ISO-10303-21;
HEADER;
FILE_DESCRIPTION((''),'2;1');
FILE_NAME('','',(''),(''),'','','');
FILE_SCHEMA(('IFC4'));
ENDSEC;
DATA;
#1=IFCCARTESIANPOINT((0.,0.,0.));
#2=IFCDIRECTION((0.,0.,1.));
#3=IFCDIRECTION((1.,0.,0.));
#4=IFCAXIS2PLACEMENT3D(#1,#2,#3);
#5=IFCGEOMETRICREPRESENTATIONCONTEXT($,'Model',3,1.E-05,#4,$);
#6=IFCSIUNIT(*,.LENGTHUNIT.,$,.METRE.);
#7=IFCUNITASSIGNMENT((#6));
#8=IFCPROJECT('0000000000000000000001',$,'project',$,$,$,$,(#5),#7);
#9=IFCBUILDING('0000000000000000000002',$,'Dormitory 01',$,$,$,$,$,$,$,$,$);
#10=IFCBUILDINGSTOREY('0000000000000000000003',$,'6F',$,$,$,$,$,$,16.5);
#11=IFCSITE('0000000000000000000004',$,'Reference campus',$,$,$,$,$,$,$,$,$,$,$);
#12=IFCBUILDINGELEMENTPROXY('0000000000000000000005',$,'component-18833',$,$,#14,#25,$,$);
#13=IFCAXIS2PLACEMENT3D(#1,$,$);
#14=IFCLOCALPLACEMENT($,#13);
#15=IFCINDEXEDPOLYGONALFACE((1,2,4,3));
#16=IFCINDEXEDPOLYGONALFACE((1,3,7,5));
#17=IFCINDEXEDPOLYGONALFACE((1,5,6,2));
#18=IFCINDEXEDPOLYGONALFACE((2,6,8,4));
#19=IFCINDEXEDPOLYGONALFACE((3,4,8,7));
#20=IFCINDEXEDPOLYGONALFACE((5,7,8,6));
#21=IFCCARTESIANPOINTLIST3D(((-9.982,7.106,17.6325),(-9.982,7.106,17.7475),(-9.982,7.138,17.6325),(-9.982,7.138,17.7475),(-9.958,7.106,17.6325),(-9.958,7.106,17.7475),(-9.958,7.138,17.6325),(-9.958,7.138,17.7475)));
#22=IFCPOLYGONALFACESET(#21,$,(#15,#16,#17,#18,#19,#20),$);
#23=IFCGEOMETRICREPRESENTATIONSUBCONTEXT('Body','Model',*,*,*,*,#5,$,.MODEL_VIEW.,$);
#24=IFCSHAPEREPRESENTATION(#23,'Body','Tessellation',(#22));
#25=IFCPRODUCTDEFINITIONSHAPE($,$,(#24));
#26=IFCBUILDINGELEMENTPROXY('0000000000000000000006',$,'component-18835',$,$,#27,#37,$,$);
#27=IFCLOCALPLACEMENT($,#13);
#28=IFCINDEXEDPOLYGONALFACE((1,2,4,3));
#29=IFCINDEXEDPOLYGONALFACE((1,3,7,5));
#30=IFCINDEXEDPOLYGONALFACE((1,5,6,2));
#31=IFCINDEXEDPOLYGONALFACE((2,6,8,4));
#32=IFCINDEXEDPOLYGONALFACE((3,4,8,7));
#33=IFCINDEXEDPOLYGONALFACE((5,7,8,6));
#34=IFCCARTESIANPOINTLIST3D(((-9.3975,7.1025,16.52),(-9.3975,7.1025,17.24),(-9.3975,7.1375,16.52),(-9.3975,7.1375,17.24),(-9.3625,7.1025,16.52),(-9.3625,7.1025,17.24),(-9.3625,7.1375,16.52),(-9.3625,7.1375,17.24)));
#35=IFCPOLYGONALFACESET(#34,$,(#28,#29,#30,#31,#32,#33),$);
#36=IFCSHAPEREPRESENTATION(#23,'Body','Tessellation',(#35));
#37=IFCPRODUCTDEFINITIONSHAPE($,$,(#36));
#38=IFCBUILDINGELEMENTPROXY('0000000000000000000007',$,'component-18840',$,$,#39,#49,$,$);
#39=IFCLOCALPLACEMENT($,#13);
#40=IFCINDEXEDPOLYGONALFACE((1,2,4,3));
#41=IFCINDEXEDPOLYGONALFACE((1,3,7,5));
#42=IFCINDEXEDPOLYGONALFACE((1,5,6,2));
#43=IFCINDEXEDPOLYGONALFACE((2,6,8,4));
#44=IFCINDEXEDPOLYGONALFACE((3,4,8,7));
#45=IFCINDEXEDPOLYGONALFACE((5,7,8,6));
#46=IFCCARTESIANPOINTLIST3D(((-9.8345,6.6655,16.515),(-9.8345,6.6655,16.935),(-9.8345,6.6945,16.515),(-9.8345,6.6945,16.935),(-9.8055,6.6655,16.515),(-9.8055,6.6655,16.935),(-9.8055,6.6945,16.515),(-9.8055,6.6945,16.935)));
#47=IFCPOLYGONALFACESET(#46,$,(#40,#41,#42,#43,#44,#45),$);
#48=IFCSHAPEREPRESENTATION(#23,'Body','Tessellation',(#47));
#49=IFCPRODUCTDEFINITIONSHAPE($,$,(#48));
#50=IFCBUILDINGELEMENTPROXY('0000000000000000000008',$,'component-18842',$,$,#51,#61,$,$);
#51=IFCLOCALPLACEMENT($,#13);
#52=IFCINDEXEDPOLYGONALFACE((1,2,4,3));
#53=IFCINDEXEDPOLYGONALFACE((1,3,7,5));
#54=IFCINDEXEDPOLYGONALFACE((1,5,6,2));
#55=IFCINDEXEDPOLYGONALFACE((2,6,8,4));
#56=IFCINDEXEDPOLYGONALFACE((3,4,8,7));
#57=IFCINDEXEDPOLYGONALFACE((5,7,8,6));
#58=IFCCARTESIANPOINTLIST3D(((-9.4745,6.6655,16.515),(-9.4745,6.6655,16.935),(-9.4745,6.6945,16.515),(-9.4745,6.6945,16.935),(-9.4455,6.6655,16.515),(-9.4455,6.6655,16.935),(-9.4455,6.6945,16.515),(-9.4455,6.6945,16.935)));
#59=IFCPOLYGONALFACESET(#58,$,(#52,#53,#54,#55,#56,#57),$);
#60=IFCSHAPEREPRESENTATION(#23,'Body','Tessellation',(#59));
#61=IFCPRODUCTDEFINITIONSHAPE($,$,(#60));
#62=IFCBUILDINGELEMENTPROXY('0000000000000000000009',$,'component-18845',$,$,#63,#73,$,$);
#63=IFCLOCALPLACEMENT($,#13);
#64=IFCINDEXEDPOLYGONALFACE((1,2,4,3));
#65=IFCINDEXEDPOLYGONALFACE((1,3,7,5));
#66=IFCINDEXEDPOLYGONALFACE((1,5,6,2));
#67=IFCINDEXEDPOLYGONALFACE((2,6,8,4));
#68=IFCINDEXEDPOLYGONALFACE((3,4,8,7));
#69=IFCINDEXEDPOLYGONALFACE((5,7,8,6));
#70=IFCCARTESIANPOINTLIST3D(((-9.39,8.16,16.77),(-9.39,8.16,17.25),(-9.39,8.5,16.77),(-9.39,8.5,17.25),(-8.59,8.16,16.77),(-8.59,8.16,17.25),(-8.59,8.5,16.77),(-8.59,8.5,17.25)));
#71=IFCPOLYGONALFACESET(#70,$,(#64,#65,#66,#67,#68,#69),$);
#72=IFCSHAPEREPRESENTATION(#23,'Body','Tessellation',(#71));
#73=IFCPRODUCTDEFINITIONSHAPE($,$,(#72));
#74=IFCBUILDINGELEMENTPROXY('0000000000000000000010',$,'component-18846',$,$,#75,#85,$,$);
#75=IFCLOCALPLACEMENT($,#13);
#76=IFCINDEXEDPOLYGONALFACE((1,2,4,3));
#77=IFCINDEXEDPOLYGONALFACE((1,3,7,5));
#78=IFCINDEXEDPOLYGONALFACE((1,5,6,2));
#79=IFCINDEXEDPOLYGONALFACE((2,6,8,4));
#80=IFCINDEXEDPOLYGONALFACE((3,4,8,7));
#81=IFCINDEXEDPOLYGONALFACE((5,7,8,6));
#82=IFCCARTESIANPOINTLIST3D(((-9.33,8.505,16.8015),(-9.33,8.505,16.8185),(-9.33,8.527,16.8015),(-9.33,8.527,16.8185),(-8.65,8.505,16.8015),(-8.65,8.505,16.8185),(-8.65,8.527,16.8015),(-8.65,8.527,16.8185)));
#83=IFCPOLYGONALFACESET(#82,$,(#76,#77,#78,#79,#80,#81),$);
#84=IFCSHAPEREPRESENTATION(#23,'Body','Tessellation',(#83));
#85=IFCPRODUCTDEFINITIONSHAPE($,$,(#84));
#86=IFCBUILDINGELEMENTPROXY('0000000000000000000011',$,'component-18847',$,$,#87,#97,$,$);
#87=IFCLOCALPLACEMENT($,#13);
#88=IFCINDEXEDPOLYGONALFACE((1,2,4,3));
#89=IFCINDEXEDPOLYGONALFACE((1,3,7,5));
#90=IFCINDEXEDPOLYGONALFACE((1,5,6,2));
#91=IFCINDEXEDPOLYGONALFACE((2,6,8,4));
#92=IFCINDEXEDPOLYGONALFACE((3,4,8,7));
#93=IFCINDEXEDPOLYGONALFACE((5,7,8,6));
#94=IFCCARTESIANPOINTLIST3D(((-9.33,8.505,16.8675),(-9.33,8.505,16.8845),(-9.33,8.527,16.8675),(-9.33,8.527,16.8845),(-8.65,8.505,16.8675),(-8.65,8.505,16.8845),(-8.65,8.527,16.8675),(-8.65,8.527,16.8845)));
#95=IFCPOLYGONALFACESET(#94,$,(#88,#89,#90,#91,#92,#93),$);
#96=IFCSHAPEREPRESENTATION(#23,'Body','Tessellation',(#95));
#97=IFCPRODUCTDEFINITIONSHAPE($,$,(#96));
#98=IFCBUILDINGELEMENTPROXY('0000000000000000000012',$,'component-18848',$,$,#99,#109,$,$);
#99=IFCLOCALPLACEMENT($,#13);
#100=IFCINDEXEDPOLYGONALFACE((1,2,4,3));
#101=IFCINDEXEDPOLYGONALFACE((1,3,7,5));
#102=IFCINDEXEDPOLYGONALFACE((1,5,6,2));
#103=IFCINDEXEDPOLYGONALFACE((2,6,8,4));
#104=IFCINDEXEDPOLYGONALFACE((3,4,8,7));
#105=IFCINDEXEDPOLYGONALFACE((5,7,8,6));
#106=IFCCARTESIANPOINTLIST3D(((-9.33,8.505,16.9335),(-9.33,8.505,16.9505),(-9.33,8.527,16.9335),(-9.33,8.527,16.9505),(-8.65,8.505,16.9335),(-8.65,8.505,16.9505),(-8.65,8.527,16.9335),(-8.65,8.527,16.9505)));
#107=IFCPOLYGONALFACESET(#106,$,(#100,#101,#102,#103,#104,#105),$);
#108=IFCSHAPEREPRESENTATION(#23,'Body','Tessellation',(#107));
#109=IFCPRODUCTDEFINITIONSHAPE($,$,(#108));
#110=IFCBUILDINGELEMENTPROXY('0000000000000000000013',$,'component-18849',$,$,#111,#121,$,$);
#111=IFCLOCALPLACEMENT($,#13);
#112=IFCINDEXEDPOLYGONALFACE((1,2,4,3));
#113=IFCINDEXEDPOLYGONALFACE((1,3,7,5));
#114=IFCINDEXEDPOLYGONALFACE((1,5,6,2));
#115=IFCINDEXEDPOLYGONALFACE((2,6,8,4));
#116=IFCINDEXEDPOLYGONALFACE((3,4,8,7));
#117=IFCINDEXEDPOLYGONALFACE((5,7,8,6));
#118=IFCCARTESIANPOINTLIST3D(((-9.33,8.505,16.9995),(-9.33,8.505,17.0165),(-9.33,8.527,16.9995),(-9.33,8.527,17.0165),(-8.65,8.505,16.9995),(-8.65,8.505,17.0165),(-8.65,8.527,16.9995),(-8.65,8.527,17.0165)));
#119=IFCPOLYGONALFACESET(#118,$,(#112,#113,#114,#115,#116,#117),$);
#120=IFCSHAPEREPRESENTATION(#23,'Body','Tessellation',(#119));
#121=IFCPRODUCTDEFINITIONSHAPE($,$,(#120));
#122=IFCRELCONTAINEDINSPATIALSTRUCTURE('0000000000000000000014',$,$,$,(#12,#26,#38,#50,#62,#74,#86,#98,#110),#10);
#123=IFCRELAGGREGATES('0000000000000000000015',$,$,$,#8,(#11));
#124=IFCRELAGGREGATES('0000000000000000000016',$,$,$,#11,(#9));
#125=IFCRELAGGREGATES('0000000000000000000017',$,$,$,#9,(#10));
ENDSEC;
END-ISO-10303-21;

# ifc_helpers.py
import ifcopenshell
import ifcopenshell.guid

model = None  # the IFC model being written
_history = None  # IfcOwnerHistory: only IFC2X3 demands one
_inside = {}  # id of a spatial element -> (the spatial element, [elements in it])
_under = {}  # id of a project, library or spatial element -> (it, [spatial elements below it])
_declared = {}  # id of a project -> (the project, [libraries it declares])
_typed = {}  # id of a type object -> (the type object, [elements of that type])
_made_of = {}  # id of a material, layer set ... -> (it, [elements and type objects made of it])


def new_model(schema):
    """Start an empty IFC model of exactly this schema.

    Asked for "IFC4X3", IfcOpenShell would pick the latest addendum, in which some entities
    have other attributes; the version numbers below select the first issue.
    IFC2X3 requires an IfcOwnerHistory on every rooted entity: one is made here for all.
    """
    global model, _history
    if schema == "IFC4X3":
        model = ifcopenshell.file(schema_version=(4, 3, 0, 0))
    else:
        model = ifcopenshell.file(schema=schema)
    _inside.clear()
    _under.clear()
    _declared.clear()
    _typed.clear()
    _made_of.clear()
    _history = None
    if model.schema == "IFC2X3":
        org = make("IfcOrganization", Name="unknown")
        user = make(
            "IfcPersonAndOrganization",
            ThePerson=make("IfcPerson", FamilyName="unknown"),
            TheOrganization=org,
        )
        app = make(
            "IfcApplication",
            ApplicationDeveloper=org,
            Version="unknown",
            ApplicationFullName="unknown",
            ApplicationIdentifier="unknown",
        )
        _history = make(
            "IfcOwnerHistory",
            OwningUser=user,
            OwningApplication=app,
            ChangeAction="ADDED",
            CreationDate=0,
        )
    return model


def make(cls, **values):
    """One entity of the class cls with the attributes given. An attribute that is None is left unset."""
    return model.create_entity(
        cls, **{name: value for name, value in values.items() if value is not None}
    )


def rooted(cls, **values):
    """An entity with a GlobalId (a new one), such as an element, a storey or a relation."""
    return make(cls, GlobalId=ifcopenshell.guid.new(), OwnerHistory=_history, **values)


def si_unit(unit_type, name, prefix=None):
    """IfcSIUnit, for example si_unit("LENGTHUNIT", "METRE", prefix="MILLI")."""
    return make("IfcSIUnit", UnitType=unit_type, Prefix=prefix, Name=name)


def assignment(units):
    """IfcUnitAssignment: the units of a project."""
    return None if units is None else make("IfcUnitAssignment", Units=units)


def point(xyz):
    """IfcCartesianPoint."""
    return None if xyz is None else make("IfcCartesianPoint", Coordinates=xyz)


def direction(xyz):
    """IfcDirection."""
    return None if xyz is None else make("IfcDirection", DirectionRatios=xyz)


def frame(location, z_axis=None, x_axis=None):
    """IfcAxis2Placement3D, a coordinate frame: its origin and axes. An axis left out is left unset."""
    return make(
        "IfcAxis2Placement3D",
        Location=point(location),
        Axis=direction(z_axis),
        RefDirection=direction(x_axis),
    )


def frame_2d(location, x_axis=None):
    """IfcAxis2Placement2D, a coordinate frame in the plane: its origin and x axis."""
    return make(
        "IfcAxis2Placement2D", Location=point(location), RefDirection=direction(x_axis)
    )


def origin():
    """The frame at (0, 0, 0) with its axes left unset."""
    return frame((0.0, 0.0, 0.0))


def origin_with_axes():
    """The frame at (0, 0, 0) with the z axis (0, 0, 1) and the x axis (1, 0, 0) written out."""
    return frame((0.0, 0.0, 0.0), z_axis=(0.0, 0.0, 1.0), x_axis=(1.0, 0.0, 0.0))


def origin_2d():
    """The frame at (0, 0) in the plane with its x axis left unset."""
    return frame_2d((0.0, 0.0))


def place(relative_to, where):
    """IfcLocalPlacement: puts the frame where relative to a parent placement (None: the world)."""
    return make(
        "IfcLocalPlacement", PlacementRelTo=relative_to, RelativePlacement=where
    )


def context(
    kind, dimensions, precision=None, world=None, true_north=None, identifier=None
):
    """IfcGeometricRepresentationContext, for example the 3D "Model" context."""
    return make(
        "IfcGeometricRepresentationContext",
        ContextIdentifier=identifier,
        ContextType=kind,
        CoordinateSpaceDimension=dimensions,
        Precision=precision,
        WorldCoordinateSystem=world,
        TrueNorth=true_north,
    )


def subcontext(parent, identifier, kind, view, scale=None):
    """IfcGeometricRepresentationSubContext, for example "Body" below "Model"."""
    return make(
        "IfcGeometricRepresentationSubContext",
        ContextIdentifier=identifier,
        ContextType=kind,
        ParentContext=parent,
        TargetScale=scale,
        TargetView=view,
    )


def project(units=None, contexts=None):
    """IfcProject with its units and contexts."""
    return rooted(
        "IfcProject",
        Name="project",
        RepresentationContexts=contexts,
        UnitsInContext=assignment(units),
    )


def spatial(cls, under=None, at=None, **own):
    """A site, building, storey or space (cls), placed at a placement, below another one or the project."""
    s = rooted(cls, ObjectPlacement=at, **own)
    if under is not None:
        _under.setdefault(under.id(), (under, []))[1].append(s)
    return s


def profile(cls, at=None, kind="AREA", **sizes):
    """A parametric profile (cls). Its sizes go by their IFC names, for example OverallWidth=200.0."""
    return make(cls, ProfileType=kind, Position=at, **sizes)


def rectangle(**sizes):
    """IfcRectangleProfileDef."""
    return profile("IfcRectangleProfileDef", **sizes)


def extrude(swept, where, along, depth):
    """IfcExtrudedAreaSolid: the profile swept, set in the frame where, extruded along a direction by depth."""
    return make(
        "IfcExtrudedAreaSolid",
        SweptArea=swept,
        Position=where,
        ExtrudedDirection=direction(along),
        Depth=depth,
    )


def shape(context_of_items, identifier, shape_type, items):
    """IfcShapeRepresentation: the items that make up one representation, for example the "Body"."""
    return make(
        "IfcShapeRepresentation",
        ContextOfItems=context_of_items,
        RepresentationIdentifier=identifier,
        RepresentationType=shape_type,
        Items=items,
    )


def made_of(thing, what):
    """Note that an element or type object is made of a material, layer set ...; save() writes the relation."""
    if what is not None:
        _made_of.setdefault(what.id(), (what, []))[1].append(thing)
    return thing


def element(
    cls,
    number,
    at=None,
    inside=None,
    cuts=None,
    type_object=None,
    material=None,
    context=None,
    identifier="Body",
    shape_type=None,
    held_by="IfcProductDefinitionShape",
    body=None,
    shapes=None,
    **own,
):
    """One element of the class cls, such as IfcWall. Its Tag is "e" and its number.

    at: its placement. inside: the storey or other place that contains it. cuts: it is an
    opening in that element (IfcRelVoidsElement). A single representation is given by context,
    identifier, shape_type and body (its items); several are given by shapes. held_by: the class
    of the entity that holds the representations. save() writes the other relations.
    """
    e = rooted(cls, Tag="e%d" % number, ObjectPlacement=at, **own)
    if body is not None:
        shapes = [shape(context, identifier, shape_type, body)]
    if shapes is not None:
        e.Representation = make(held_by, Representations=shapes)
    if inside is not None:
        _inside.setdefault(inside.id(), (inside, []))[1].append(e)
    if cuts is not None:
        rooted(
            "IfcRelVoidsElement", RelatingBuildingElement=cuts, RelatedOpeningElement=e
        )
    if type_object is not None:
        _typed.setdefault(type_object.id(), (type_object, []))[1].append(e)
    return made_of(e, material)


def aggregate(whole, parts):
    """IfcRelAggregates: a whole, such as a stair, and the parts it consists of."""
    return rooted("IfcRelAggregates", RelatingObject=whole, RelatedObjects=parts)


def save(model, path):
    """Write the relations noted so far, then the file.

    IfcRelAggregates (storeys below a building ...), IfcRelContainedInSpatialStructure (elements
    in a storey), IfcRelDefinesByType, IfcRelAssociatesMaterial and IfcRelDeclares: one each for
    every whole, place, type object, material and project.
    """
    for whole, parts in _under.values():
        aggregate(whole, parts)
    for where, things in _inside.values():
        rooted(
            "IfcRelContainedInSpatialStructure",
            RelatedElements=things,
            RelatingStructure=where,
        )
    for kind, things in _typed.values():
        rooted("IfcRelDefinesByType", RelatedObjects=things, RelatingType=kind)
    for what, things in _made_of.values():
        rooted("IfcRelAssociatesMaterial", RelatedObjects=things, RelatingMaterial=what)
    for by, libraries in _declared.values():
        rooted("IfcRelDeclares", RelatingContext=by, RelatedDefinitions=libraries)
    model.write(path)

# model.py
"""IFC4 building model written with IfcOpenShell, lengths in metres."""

from ifc_helpers import new_model, si_unit, frame, origin, origin_with_axes, origin_2d, place, context, subcontext, project, spatial, rectangle, extrude, element, save


model = new_model("IFC4")

# Units and contexts
model_context = context("Model", 3, precision=1e-05, world=origin_with_axes())
body_context = subcontext(model_context, "Body", "Model", "MODEL_VIEW")
ifc_project = project(units=[si_unit("LENGTHUNIT", "METRE")], contexts=[model_context])

# Site, building, storey
site = spatial("IfcSite", under=ifc_project, Name="Reference campus")
building = spatial("IfcBuilding", under=site, Name="Dormitory 01")
storey = spatial("IfcBuildingStorey", under=building, Name="6F", Elevation=16.5)

# Building element proxies
for number, where, z_axis, x_axis, name in (
    (1, (-9.97, 7.122, 17.6325), (0.0, 0.0, 1.0), (1.0, 0.0, 0.0), "component-18833"),
):
    element("IfcBuildingElementProxy", number, at=place(None, frame(where, z_axis=z_axis, x_axis=x_axis)), inside=storey, Name=name, context=body_context, shape_type="SweptSolid", body=[
        extrude(rectangle(XDim=0.024, YDim=0.032, at=origin_2d()), origin(), (0.0, 0.0, 1.0), 0.115),
    ])
proxy_1_placement = place(None, frame((-9.38, 7.12, 16.52), z_axis=(0.0, 0.0, 1.0), x_axis=(1.0, 0.0, 0.0)))
element("IfcBuildingElementProxy", 2, at=proxy_1_placement, inside=storey, Name="component-18835", context=body_context, shape_type="SweptSolid", body=[
    extrude(rectangle(XDim=0.035, YDim=0.035, at=origin_2d()), origin(), (0.0, 0.0, 1.0), 0.72),
])
for number, where, z_axis, x_axis, name in (
    (3, (-9.82, 6.68, 16.515), (0.0, 0.0, 1.0), (1.0, 0.0, 0.0), "component-18840"),
    (4, (-9.46, 6.68, 16.515), (0.0, 0.0, 1.0), (1.0, 0.0, 0.0), "component-18842"),
):
    element("IfcBuildingElementProxy", number, at=place(None, frame(where, z_axis=z_axis, x_axis=x_axis)), inside=storey, Name=name, context=body_context, shape_type="SweptSolid", body=[
        extrude(rectangle(XDim=0.029, YDim=0.029, at=origin_2d()), origin(), (0.0, 0.0, 1.0), 0.42),
    ])
proxy_2_placement = place(None, frame((-8.99, 8.33, 16.77), z_axis=(0.0, 0.0, 1.0), x_axis=(1.0, 0.0, 0.0)))
element("IfcBuildingElementProxy", 5, at=proxy_2_placement, inside=storey, Name="component-18845", context=body_context, shape_type="SweptSolid", body=[
    extrude(rectangle(XDim=0.8, YDim=0.34, at=origin_2d()), origin(), (0.0, 0.0, 1.0), 0.48),
])
for number, where, z_axis, x_axis, name in (
    (6, (-8.99, 8.516, 16.8015), (0.0, 0.0, 1.0), (1.0, 0.0, 0.0), "component-18846"),
    (7, (-8.99, 8.516, 16.8675), (0.0, 0.0, 1.0), (1.0, 0.0, 0.0), "component-18847"),
    (8, (-8.99, 8.516, 16.9335), (0.0, 0.0, 1.0), (1.0, 0.0, 0.0), "component-18848"),
    (9, (-8.99, 8.516, 16.9995), (0.0, 0.0, 1.0), (1.0, 0.0, 0.0), "component-18849"),
):
    element("IfcBuildingElementProxy", number, at=place(None, frame(where, z_axis=z_axis, x_axis=x_axis)), inside=storey, Name=name, context=body_context, shape_type="SweptSolid", body=[
        extrude(rectangle(XDim=0.68, YDim=0.022, at=origin_2d()), origin(), (0.0, 0.0, 1.0), 0.017),
    ])

save(model, "model.ifc")
